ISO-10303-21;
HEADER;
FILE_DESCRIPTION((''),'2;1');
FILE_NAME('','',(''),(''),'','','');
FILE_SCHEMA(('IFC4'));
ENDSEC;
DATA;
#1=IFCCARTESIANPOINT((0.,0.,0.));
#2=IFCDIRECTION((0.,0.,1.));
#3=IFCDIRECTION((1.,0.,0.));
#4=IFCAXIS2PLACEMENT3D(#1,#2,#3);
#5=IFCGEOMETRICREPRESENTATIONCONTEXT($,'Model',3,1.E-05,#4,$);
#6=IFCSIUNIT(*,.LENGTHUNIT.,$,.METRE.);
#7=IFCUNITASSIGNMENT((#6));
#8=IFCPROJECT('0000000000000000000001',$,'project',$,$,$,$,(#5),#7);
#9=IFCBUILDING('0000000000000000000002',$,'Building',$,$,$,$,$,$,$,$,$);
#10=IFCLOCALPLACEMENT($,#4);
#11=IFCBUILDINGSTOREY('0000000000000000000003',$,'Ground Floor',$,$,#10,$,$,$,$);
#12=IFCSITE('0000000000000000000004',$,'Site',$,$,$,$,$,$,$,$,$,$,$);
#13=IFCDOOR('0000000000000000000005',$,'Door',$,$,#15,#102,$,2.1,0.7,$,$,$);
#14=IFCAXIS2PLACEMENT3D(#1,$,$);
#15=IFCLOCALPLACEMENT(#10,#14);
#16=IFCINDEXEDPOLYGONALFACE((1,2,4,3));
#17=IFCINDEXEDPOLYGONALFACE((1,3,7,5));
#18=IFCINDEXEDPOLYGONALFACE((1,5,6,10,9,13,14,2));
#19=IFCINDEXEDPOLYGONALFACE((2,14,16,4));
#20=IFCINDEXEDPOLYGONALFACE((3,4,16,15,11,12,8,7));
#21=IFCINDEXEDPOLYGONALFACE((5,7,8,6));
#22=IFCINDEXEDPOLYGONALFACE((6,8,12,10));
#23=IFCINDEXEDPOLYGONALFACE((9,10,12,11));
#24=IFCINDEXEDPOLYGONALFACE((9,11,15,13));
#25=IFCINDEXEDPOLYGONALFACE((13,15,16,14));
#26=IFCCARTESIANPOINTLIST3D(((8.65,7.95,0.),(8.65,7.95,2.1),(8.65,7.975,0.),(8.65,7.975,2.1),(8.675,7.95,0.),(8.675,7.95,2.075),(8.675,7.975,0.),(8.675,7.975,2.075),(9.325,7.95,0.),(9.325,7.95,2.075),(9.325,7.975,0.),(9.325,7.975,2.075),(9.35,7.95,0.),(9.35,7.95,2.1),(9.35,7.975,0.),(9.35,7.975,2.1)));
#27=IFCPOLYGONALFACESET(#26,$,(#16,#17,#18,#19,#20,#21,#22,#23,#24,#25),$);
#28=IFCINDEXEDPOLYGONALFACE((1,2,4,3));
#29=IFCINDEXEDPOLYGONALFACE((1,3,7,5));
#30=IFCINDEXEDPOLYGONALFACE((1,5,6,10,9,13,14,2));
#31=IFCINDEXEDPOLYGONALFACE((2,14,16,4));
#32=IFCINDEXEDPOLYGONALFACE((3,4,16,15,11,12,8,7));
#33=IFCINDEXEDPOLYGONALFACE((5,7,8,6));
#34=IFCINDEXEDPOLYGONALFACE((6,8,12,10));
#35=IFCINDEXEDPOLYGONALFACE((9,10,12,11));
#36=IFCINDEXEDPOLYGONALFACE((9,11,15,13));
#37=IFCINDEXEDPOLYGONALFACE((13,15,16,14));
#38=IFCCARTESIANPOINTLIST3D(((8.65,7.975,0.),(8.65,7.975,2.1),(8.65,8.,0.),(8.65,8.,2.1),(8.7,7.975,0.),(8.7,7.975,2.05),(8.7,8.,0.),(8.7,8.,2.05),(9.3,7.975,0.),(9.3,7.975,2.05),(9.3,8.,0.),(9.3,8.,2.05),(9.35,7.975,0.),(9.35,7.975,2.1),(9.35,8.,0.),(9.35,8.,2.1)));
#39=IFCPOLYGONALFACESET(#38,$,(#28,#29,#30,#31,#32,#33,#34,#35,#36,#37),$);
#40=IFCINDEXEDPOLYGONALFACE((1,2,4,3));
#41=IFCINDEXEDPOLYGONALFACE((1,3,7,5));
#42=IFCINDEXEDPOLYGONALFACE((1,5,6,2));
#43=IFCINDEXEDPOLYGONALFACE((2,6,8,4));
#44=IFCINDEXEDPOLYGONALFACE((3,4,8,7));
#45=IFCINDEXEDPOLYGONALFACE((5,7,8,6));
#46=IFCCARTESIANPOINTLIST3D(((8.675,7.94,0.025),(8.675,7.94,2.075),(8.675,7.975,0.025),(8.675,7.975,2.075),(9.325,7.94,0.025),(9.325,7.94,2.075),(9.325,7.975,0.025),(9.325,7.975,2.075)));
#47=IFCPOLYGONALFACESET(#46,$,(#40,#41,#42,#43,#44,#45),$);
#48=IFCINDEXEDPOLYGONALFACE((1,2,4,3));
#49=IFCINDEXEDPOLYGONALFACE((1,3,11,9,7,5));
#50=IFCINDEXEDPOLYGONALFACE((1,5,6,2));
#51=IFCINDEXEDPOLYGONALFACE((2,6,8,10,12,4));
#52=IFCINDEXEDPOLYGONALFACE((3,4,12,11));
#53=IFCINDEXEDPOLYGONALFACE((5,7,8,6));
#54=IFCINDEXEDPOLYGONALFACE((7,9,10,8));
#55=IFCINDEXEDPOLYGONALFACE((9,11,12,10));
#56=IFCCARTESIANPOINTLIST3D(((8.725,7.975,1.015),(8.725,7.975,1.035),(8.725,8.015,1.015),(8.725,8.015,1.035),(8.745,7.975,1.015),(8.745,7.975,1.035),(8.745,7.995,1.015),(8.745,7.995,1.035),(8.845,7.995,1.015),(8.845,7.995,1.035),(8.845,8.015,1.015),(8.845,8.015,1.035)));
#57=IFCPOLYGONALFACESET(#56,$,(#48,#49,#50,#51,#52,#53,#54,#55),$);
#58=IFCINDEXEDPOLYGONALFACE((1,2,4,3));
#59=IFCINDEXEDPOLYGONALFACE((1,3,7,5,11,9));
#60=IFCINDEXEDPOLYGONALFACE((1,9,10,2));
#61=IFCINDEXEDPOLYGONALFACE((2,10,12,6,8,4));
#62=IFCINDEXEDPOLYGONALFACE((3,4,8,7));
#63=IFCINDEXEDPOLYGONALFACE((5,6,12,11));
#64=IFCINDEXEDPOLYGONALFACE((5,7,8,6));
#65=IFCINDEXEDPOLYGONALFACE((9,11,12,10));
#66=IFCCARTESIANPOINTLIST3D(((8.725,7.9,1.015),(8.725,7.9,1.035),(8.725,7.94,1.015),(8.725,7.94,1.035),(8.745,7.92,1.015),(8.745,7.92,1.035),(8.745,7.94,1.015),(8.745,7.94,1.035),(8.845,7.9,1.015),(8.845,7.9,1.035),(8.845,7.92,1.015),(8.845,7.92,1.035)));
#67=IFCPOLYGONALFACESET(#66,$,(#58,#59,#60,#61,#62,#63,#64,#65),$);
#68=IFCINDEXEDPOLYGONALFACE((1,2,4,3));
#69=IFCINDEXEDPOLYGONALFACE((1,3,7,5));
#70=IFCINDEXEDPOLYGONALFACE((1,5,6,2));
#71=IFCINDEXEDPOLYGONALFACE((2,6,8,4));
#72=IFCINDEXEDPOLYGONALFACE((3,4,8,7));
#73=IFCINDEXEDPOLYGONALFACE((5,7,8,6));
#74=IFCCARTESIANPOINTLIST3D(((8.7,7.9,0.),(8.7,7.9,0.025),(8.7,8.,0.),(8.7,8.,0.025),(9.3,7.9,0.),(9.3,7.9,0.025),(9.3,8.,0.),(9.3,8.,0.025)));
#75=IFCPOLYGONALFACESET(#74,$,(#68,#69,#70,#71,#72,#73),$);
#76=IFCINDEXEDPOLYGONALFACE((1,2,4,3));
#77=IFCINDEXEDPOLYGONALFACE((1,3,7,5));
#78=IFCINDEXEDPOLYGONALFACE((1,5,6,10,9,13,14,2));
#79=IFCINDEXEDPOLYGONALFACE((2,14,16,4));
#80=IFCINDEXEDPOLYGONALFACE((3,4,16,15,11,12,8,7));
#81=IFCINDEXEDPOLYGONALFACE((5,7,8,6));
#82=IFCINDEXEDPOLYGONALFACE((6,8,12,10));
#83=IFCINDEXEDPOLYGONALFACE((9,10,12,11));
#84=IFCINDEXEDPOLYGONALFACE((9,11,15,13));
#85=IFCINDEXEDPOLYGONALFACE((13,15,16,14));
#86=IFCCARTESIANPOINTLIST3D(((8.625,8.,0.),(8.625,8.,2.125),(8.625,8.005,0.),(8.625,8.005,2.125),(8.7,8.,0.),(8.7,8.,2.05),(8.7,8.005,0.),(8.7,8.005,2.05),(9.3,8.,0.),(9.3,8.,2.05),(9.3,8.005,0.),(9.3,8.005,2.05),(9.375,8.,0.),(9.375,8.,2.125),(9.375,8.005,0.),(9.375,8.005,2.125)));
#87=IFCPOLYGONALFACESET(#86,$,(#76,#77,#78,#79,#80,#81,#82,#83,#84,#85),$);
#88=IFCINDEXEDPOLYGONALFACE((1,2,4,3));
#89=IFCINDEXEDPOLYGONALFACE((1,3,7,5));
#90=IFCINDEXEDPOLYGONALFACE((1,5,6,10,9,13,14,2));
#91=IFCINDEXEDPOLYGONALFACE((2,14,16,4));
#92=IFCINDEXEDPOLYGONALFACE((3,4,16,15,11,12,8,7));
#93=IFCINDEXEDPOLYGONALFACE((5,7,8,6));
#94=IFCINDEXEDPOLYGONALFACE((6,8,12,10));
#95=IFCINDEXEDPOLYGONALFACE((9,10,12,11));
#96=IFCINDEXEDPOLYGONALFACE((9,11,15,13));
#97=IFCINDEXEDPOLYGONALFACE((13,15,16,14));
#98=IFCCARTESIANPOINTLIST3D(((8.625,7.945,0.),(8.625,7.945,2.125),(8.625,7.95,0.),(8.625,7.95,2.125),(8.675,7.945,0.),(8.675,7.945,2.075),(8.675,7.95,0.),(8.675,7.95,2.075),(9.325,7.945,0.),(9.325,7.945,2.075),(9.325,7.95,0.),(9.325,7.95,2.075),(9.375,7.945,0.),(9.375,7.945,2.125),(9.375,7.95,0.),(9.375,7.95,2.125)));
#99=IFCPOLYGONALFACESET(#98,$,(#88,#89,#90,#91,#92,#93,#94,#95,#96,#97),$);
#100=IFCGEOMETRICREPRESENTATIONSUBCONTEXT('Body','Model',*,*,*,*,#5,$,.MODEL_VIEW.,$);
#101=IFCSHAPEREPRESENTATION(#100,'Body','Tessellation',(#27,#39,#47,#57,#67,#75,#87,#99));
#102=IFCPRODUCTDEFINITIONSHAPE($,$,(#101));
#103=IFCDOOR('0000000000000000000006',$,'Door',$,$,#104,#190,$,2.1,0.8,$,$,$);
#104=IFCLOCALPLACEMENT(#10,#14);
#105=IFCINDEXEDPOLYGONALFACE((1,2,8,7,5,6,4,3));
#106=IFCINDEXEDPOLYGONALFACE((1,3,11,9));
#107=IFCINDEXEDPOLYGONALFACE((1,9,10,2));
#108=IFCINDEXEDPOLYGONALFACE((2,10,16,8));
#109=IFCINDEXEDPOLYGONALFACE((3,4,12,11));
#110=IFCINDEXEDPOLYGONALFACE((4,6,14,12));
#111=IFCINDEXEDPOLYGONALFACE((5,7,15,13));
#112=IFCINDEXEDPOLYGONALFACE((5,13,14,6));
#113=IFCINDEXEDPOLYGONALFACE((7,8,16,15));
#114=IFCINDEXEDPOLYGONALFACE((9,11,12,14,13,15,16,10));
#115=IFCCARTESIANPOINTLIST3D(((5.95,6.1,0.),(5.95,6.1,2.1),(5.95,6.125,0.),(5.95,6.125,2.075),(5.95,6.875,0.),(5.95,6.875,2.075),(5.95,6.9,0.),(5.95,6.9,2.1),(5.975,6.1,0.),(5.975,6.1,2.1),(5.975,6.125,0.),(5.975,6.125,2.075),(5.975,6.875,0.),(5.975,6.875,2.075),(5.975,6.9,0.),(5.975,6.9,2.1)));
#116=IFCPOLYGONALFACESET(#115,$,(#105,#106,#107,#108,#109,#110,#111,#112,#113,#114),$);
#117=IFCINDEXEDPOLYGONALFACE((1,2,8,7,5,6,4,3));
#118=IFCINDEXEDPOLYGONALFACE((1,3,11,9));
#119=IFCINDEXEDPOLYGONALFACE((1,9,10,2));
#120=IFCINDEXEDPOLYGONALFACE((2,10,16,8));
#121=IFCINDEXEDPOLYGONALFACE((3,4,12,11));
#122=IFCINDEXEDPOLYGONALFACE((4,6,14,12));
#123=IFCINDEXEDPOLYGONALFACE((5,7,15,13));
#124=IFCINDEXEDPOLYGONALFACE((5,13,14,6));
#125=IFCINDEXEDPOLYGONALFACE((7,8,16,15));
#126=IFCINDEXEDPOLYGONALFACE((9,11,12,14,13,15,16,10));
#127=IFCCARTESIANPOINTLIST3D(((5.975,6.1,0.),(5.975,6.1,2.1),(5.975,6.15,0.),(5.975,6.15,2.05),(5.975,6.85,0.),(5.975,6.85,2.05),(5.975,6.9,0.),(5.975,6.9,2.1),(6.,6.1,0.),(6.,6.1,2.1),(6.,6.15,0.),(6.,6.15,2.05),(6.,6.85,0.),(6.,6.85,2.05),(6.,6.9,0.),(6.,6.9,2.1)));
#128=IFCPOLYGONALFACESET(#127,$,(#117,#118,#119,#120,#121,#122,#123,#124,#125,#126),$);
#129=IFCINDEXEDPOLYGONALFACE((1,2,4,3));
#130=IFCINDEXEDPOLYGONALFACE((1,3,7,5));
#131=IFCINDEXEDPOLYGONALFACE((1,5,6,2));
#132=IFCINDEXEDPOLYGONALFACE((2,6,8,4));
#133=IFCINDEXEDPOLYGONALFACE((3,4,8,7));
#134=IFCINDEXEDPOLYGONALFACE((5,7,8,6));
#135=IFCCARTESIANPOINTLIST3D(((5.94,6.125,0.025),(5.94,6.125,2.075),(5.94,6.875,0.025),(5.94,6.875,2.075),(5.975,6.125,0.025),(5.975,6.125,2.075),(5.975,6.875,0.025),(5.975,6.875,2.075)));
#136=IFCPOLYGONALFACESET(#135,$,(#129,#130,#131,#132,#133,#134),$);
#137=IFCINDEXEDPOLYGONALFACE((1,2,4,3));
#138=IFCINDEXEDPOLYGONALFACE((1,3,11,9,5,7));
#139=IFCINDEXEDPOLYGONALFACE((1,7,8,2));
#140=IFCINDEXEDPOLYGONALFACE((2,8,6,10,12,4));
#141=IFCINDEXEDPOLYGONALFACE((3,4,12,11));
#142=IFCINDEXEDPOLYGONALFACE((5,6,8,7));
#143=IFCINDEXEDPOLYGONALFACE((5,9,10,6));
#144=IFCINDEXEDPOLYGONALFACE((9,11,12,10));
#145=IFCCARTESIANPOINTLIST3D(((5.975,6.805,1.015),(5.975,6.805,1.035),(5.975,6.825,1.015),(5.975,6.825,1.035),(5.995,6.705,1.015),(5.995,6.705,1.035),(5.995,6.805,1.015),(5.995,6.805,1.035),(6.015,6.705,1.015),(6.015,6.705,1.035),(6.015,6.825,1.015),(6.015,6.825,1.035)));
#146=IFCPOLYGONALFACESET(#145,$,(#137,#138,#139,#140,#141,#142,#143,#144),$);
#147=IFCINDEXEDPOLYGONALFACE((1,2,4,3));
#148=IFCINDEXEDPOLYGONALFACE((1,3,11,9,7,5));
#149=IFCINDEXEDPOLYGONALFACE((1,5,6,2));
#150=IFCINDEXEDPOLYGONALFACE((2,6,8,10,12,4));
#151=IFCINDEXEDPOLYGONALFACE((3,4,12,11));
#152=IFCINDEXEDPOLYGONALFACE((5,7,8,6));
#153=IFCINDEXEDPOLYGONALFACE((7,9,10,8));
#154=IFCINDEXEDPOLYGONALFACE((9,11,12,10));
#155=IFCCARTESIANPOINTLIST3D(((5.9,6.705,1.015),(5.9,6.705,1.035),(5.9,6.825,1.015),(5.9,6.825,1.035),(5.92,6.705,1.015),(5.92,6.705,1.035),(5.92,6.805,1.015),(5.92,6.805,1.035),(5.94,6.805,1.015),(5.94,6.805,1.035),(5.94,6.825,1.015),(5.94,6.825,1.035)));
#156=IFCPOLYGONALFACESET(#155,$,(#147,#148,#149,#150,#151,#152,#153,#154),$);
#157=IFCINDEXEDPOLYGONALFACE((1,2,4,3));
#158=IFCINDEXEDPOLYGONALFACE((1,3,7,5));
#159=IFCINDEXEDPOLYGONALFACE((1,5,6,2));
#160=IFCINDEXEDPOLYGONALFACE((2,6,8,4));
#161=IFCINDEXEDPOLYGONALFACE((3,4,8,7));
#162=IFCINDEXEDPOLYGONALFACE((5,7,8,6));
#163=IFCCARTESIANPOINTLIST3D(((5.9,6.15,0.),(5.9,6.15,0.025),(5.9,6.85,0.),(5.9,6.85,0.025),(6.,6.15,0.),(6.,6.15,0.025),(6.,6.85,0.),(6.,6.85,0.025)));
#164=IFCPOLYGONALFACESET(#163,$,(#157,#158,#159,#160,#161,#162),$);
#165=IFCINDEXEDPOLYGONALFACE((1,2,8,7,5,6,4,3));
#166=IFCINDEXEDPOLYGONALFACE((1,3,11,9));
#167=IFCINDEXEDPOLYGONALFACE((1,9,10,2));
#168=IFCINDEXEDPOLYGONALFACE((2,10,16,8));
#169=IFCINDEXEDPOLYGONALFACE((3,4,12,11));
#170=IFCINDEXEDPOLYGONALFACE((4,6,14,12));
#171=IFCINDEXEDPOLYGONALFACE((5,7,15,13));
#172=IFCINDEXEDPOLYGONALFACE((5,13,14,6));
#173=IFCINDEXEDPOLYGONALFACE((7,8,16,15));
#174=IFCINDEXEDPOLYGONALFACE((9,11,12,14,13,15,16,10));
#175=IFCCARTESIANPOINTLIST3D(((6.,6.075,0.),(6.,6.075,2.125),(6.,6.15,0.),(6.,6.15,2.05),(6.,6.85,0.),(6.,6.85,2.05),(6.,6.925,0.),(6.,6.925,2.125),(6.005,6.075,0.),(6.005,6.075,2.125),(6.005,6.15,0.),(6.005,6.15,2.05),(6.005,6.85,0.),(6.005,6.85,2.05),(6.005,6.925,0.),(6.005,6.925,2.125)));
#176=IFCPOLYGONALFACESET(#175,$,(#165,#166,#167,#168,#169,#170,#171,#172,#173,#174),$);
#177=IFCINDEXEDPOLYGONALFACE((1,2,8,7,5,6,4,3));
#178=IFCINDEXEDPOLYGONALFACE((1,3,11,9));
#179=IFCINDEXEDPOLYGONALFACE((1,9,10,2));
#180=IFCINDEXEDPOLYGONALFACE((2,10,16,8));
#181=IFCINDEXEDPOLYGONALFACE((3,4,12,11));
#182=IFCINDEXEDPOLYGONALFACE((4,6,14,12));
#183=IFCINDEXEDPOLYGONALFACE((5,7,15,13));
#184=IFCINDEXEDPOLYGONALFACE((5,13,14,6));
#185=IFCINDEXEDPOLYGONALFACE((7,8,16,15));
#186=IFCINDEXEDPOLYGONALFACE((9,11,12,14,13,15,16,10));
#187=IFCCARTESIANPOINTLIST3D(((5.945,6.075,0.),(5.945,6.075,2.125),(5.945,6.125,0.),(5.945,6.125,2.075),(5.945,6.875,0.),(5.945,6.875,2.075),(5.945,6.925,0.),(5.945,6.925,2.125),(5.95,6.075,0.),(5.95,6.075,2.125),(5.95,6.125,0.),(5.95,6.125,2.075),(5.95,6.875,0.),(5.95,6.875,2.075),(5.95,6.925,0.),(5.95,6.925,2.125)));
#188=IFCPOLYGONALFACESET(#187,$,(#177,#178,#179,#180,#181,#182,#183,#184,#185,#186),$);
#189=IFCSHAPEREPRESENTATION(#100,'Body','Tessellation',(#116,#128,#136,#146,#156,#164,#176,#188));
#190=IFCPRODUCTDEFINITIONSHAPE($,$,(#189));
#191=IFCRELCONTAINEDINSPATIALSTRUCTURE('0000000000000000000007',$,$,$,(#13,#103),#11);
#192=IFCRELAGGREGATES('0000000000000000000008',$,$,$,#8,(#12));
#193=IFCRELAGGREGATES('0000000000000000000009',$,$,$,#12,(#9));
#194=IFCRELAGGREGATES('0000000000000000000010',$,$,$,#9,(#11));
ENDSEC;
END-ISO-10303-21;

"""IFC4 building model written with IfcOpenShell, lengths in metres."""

from ifc_helpers import new_model, si_unit, frame, origin_with_axes, place, context, subcontext, project, spatial, line, indexed_curve, outline, extrude, element, save


model = new_model("IFC4")

# Units and contexts
model_context = context("Model", 3, precision=1e-05, world=origin_with_axes())
body_context = subcontext(model_context, "Body", "Model", "MODEL_VIEW")
ifc_project = project(units=[si_unit("LENGTHUNIT", "METRE")], contexts=[model_context])

# Site, building, storey
site = spatial("IfcSite", under=ifc_project, Name="Site")
building = spatial("IfcBuilding", under=site, Name="Building")
storey_placement = place(None, origin_with_axes())
storey = spatial("IfcBuildingStorey", under=building, at=storey_placement, Name="Ground Floor")

# Doors
door_1_placement = place(storey_placement, frame((9.35, 8.0, 0.0), z_axis=(0.0, 0.0, 1.0), x_axis=(-1.0, 0.0, 0.0)))
element("IfcDoor", 1, at=door_1_placement, inside=storey, Name="Door", OverallHeight=2.1, OverallWidth=0.7, context=body_context, shape_type="SweptSolid", body=[
    extrude(outline(indexed_curve([(0.0, 0.0), (0.0, 2.1), (0.7, 2.1), (0.7, 0.0), (0.675, 0.0), (0.675, 2.075), (0.025, 2.075), (0.025, 0.0)], segments=[line(1, 2, 3, 4, 5, 6, 7, 8, 1)])), frame((0.0, 0.025, 0.0), z_axis=(0.0, -1.0, 0.0), x_axis=(1.0, 0.0, 0.0)), (0.0, 0.0, -1.0), 0.025),
    extrude(outline(indexed_curve([(0.0, 0.0), (0.0, 2.1), (0.7, 2.1), (0.7, 0.0), (0.65, 0.0), (0.65, 2.05), (0.05, 2.05), (0.05, 0.0)], segments=[line(1, 2, 3, 4, 5, 6, 7, 8, 1)])), frame((0.0, 0.0, 0.0), z_axis=(0.0, -1.0, 0.0), x_axis=(1.0, 0.0, 0.0)), (0.0, 0.0, -1.0), 0.025),
    extrude(outline(indexed_curve([(0.0, 0.0), (0.65, 0.0), (0.65, 0.035), (0.0, 0.035)], segments=[line(1, 2, 3, 4, 1)])), frame((0.025, 0.025, 0.025), z_axis=(0.0, 0.0, 1.0), x_axis=(1.0, 0.0, 0.0)), (0.0, 0.0, 1.0), 2.05),
    extrude(outline(indexed_curve([(0.0, 0.0), (0.0, -0.04), (-0.12, -0.04), (-0.12, -0.02), (-0.02, -0.02), (-0.02, 0.0)], segments=[line(1, 2, 3, 4, 5, 6, 1)])), frame((0.625, 0.025, 1.015), z_axis=(0.0, 0.0, 1.0), x_axis=(1.0, 0.0, 0.0)), (0.0, 0.0, 1.0), 0.02),
    extrude(outline(indexed_curve([(0.0, 0.0), (0.0, 0.04), (-0.12, 0.04), (-0.12, 0.02), (-0.02, 0.02), (-0.02, 0.0)], segments=[line(1, 2, 3, 4, 5, 6, 1)])), frame((0.625, 0.06, 1.015), z_axis=(0.0, 0.0, 1.0), x_axis=(1.0, 0.0, 0.0)), (0.0, 0.0, 1.0), 0.02),
    extrude(outline(indexed_curve([(0.0, 0.0), (0.6, 0.0), (0.6, 0.1), (0.0, 0.1)], segments=[line(1, 2, 3, 4, 1)])), frame((0.05, 0.0, 0.0), z_axis=(0.0, 0.0, 1.0), x_axis=(1.0, 0.0, 0.0)), (0.0, 0.0, 1.0), 0.025),
    extrude(outline(indexed_curve([(0.0, 0.0), (0.0, 2.125), (0.75, 2.125), (0.75, 0.0), (0.675, 0.0), (0.675, 2.05), (0.075, 2.05), (0.075, 0.0)], segments=[line(1, 2, 3, 4, 5, 6, 7, 8, 1)])), frame((-0.025, -0.005, 0.0), z_axis=(0.0, -1.0, 0.0), x_axis=(1.0, 0.0, 0.0)), (0.0, 0.0, -1.0), 0.005),
    extrude(outline(indexed_curve([(0.0, 0.0), (0.0, 2.125), (0.75, 2.125), (0.75, 0.0), (0.7, 0.0), (0.7, 2.075), (0.05, 2.075), (0.05, 0.0)], segments=[line(1, 2, 3, 4, 5, 6, 7, 8, 1)])), frame((-0.025, 0.05, 0.0), z_axis=(0.0, -1.0, 0.0), x_axis=(1.0, 0.0, 0.0)), (0.0, 0.0, -1.0), 0.005),
])
door_2_placement = place(storey_placement, frame((6.0, 6.1, 0.0), z_axis=(0.0, 0.0, 1.0), x_axis=(0.0, 1.0, 0.0)))
element("IfcDoor", 2, at=door_2_placement, inside=storey, Name="Door", OverallHeight=2.1, OverallWidth=0.8, context=body_context, shape_type="SweptSolid", body=[
    extrude(outline(indexed_curve([(0.0, 0.0), (0.0, 2.1), (0.8, 2.1), (0.8, 0.0), (0.775, 0.0), (0.775, 2.075), (0.025, 2.075), (0.025, 0.0)], segments=[line(1, 2, 3, 4, 5, 6, 7, 8, 1)])), frame((0.0, 0.025, 0.0), z_axis=(0.0, -1.0, 0.0), x_axis=(1.0, 0.0, 0.0)), (0.0, 0.0, -1.0), 0.025),
    extrude(outline(indexed_curve([(0.0, 0.0), (0.0, 2.1), (0.8, 2.1), (0.8, 0.0), (0.75, 0.0), (0.75, 2.05), (0.05, 2.05), (0.05, 0.0)], segments=[line(1, 2, 3, 4, 5, 6, 7, 8, 1)])), frame((0.0, 0.0, 0.0), z_axis=(0.0, -1.0, 0.0), x_axis=(1.0, 0.0, 0.0)), (0.0, 0.0, -1.0), 0.025),
    extrude(outline(indexed_curve([(0.0, 0.0), (0.75, 0.0), (0.75, 0.035), (0.0, 0.035)], segments=[line(1, 2, 3, 4, 1)])), frame((0.025, 0.025, 0.025), z_axis=(0.0, 0.0, 1.0), x_axis=(1.0, 0.0, 0.0)), (0.0, 0.0, 1.0), 2.05),
    extrude(outline(indexed_curve([(0.0, 0.0), (0.0, -0.04), (-0.12, -0.04), (-0.12, -0.02), (-0.02, -0.02), (-0.02, 0.0)], segments=[line(1, 2, 3, 4, 5, 6, 1)])), frame((0.725, 0.025, 1.015), z_axis=(0.0, 0.0, 1.0), x_axis=(1.0, 0.0, 0.0)), (0.0, 0.0, 1.0), 0.02),
    extrude(outline(indexed_curve([(0.0, 0.0), (0.0, 0.04), (-0.12, 0.04), (-0.12, 0.02), (-0.02, 0.02), (-0.02, 0.0)], segments=[line(1, 2, 3, 4, 5, 6, 1)])), frame((0.725, 0.06, 1.015), z_axis=(0.0, 0.0, 1.0), x_axis=(1.0, 0.0, 0.0)), (0.0, 0.0, 1.0), 0.02),
    extrude(outline(indexed_curve([(0.0, 0.0), (0.7, 0.0), (0.7, 0.1), (0.0, 0.1)], segments=[line(1, 2, 3, 4, 1)])), frame((0.05, 0.0, 0.0), z_axis=(0.0, 0.0, 1.0), x_axis=(1.0, 0.0, 0.0)), (0.0, 0.0, 1.0), 0.025),
    extrude(outline(indexed_curve([(0.0, 0.0), (0.0, 2.125), (0.85, 2.125), (0.85, 0.0), (0.775, 0.0), (0.775, 2.05), (0.075, 2.05), (0.075, 0.0)], segments=[line(1, 2, 3, 4, 5, 6, 7, 8, 1)])), frame((-0.025, -0.005, 0.0), z_axis=(0.0, -1.0, 0.0), x_axis=(1.0, 0.0, 0.0)), (0.0, 0.0, -1.0), 0.005),
    extrude(outline(indexed_curve([(0.0, 0.0), (0.0, 2.125), (0.85, 2.125), (0.85, 0.0), (0.8, 0.0), (0.8, 2.075), (0.05, 2.075), (0.05, 0.0)], segments=[line(1, 2, 3, 4, 5, 6, 7, 8, 1)])), frame((-0.025, 0.05, 0.0), z_axis=(0.0, -1.0, 0.0), x_axis=(1.0, 0.0, 0.0)), (0.0, 0.0, -1.0), 0.005),
])

save(model, "model.ifc")
